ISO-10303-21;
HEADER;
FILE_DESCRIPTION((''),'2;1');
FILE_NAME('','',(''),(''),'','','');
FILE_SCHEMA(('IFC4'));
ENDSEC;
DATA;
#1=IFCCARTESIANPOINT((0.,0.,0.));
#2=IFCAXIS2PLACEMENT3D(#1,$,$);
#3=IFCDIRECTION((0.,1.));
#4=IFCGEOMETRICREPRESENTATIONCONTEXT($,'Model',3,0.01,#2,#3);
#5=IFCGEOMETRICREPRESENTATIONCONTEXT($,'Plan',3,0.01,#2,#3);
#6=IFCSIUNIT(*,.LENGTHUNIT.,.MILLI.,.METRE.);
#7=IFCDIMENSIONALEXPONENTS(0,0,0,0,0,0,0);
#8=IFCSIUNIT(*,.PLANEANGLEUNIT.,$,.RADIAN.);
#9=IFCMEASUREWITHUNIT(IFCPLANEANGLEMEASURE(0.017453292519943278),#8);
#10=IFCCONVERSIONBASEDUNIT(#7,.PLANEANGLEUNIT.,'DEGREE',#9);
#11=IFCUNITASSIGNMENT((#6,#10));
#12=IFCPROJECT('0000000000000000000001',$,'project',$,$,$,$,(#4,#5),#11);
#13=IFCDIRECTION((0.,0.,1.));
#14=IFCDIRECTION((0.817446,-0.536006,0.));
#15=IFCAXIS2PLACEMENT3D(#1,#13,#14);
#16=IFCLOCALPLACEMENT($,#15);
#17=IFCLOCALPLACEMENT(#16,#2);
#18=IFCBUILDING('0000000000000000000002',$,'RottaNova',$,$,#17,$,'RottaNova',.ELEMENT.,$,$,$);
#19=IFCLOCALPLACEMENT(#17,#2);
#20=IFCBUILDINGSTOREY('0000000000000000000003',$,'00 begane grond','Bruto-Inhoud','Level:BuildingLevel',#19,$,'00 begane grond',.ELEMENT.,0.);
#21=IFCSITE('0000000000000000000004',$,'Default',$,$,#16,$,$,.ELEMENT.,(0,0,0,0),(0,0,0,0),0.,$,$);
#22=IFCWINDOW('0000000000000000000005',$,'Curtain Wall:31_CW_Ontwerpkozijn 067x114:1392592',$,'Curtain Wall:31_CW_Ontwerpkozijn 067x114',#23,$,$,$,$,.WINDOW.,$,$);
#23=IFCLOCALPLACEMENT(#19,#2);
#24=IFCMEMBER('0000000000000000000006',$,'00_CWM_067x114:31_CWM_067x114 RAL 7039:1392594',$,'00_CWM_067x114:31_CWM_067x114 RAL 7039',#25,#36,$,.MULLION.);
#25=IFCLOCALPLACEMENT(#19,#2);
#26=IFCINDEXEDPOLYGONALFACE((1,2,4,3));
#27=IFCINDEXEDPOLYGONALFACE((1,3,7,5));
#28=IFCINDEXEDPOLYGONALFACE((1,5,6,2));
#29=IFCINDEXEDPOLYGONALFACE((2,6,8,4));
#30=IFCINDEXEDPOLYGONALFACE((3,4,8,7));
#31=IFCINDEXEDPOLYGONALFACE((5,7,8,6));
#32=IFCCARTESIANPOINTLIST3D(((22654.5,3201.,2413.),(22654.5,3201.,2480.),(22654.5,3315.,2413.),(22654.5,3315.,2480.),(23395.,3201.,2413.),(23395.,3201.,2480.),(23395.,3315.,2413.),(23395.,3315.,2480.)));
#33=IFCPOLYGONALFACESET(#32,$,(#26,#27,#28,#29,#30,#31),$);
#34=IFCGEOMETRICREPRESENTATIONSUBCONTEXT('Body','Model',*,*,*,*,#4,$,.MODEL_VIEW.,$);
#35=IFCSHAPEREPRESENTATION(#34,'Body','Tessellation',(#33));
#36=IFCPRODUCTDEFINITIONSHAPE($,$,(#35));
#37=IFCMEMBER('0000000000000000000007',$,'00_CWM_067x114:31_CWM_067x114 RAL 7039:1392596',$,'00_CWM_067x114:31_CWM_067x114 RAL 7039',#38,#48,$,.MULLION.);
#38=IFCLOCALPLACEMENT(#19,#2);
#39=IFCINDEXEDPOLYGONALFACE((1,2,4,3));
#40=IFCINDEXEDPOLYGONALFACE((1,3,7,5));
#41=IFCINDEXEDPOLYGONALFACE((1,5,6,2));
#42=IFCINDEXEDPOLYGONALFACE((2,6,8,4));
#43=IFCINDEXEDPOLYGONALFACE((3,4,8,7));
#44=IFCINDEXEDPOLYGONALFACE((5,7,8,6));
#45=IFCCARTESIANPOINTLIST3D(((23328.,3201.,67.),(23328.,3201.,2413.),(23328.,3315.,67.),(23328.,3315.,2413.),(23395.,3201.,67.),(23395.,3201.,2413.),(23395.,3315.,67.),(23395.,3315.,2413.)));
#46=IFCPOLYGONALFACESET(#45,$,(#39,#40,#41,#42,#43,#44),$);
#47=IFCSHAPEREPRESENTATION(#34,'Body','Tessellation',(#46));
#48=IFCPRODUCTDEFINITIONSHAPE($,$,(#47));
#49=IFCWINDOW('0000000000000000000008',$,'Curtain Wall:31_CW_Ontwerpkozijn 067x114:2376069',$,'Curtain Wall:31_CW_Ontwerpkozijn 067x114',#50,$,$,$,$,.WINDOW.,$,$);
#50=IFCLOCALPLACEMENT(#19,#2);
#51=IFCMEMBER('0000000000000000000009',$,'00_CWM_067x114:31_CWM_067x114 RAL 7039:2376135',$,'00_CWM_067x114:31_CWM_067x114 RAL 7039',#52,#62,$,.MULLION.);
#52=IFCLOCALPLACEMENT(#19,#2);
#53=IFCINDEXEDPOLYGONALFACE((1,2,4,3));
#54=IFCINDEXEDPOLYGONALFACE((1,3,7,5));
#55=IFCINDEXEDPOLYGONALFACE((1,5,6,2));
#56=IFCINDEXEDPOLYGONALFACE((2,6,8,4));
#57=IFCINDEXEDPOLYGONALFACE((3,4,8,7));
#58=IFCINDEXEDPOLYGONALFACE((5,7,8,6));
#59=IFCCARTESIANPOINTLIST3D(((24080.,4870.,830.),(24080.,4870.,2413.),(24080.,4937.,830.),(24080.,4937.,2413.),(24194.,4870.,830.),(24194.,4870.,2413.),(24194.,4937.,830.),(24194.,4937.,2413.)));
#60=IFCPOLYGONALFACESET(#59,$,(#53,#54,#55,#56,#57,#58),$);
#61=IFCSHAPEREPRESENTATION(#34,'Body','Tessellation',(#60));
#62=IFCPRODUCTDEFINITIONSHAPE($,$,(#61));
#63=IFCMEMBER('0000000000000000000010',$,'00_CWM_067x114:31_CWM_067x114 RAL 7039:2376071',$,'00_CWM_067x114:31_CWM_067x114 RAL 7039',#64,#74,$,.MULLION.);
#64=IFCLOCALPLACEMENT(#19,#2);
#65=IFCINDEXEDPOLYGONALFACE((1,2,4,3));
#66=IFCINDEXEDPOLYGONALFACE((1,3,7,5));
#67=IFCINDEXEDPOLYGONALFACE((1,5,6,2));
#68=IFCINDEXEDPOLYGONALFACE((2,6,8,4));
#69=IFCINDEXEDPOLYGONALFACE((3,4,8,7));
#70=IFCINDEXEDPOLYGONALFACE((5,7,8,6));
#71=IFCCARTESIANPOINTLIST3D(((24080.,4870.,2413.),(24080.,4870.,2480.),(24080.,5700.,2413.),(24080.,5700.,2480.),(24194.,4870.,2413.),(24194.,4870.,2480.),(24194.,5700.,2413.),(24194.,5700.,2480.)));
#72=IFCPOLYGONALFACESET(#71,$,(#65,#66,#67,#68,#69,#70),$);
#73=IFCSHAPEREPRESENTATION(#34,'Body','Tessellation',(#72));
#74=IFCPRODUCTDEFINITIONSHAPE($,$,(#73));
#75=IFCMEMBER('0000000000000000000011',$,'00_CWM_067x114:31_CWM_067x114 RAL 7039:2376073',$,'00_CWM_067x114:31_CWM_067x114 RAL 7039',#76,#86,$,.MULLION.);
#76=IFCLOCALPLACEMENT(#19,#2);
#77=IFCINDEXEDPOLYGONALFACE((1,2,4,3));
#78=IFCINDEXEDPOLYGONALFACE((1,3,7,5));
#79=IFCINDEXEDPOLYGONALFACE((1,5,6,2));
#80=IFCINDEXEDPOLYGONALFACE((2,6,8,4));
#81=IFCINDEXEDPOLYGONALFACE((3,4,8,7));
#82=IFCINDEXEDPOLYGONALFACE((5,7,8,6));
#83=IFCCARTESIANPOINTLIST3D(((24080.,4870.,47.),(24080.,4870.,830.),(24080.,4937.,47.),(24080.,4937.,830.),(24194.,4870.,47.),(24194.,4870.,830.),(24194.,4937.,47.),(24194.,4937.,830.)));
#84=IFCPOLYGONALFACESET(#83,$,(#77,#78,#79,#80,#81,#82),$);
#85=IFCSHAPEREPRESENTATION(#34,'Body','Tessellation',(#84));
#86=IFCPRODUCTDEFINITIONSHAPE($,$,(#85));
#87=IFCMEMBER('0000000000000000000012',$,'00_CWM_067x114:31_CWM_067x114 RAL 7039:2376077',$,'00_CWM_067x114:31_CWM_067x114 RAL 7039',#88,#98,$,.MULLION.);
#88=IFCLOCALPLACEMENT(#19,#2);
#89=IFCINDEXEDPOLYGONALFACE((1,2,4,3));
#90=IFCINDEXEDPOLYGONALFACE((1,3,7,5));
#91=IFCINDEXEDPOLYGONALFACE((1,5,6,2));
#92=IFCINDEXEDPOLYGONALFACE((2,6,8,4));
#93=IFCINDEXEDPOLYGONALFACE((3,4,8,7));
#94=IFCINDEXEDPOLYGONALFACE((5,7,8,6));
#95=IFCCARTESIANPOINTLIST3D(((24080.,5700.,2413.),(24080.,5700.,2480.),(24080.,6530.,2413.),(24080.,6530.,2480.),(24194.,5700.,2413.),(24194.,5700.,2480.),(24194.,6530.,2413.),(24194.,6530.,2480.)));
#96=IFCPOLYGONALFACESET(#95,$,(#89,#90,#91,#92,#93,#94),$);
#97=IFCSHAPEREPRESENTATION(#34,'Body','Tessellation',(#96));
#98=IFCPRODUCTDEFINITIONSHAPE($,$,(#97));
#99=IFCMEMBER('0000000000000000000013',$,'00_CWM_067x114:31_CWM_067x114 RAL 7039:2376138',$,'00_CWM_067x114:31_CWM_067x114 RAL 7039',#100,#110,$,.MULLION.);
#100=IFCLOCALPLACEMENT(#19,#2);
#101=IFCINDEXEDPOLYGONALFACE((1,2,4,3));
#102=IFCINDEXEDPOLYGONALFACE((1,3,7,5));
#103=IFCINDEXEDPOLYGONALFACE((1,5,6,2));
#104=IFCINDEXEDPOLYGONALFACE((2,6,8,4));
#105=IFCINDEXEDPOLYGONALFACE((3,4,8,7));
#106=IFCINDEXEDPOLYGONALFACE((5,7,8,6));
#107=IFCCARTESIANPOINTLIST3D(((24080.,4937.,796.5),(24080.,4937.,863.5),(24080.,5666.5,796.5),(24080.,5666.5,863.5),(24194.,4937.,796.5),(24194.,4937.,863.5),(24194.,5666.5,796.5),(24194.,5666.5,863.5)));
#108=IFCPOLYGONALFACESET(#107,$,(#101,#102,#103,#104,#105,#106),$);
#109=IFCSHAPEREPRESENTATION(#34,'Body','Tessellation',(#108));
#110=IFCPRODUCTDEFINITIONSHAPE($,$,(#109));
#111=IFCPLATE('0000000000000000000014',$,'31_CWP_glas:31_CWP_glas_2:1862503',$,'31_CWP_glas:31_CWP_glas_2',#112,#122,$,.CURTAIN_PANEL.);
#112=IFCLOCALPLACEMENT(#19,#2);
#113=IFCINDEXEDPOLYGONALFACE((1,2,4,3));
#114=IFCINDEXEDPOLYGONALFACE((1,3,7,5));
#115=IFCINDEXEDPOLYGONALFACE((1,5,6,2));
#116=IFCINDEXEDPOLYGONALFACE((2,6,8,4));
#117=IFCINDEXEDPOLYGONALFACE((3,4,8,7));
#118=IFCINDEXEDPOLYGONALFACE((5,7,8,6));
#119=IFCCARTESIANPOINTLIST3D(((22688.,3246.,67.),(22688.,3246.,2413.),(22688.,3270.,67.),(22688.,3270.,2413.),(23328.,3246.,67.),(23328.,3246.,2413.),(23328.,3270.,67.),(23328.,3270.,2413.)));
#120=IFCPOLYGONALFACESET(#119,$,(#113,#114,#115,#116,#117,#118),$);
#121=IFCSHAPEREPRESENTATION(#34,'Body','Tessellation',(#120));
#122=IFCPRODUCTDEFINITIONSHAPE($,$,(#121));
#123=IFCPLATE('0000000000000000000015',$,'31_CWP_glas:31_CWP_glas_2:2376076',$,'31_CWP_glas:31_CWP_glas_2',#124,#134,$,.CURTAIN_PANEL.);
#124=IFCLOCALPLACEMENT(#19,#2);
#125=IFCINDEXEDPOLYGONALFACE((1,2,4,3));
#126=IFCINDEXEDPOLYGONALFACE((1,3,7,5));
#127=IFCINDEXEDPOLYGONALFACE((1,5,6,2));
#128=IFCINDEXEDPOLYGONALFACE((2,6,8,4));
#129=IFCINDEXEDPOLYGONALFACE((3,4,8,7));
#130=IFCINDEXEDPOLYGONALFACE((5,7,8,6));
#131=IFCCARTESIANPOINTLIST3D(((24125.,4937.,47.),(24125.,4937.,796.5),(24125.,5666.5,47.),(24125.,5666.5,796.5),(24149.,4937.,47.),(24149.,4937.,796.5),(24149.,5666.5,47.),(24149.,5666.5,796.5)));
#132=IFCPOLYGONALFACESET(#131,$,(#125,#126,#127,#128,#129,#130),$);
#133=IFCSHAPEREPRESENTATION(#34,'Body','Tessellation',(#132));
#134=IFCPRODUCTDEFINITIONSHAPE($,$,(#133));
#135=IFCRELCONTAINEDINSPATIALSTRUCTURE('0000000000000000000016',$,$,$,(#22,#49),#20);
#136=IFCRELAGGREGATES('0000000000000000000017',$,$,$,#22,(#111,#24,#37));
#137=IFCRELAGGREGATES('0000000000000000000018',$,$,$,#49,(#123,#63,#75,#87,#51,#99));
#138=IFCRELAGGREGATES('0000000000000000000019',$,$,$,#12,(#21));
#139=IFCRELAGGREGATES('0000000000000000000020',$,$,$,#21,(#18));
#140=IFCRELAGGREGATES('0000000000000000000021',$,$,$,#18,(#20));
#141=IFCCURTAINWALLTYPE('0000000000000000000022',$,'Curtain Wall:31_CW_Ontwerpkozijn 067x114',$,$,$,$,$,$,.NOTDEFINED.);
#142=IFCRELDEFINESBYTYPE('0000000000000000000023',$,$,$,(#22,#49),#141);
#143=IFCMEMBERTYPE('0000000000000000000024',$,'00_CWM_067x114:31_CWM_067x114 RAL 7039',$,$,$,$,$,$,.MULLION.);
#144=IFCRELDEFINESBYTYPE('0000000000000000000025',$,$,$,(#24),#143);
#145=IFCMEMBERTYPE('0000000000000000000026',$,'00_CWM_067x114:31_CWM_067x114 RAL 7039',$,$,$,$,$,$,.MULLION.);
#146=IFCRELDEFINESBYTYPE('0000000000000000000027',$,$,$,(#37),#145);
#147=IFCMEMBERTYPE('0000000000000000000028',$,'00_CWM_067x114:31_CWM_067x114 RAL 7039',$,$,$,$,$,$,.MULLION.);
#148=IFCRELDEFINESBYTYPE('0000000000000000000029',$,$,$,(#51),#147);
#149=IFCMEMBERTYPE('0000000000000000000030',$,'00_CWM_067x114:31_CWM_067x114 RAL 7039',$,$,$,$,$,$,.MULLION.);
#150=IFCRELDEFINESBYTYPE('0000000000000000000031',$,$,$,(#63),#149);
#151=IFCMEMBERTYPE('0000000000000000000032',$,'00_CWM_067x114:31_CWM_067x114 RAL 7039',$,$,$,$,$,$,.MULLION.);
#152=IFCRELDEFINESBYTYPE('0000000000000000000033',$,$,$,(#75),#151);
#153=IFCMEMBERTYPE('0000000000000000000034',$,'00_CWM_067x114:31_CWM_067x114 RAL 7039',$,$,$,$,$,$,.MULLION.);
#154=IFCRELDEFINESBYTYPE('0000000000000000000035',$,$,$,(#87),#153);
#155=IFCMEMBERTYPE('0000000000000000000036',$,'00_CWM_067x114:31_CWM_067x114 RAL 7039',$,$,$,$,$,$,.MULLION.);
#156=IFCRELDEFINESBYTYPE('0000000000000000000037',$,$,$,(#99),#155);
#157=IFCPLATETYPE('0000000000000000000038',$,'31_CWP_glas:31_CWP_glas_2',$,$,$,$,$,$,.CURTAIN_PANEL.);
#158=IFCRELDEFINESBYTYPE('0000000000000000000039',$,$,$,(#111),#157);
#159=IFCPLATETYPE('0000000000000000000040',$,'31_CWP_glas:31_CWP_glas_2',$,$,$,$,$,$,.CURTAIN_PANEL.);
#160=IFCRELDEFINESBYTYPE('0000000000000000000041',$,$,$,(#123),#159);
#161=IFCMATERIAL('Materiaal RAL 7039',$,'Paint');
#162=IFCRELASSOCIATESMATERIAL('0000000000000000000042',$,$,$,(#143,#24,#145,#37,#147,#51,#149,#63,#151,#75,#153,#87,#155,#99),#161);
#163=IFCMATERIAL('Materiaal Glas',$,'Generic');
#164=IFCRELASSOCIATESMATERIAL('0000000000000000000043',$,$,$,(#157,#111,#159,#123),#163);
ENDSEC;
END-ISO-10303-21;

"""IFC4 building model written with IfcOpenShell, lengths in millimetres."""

from ifc_helpers import new_model, entity, si_unit, converted_unit, direction, frame, origin, place, context, subcontext, project, spatial, indexed_curve, outline, extrude, source, transform, mapped, material, type_object, type_shapes, element, aggregate, save


model = new_model("IFC4")

# Units and contexts
model_context = context("Model", 3, precision=0.01, world=origin(), true_north=direction((0.0, 1.0)))
plan_context = context("Plan", 3, precision=0.01, world=origin(), true_north=direction((0.0, 1.0)))
body_context = subcontext(model_context, "Body", "Model", "MODEL_VIEW")
ifc_project = project(units=[si_unit("LENGTHUNIT", "METRE", prefix="MILLI"), converted_unit("PLANEANGLEUNIT", "DEGREE", entity("IfcPlaneAngleMeasure", 0.017453292519943278), si_unit("PLANEANGLEUNIT", "RADIAN"), dimensions=[0, 0, 0, 0, 0, 0, 0])], contexts=[model_context, plan_context])

# Site, building, storey
site_placement = place(None, frame((0.0, 0.0, 0.0), z_axis=(0.0, 0.0, 1.0), x_axis=(0.817446, -0.536006, 0.0)))
site = spatial("IfcSite", under=ifc_project, at=site_placement, Name="Default", CompositionType="ELEMENT", RefLatitude=(0, 0, 0, 0), RefLongitude=(0, 0, 0, 0), RefElevation=0.0)
building_placement = place(site_placement, origin())
building = spatial("IfcBuilding", under=site, at=building_placement, Name="RottaNova", LongName="RottaNova", CompositionType="ELEMENT")
storey_placement = place(building_placement, origin())
storey = spatial("IfcBuildingStorey", under=building, at=storey_placement, Name="00 begane grond", Description="Bruto-Inhoud", ObjectType="Level:BuildingLevel", LongName="00 begane grond", CompositionType="ELEMENT", Elevation=0.0)

# Windows, members
curtain_wall_type = type_object("IfcCurtainWallType", Name="Curtain Wall:31_CW_Ontwerpkozijn 067x114", PredefinedType="NOTDEFINED")
window_1_placement = place(storey_placement, origin())
window_1 = element("IfcWindow", 1, at=window_1_placement, inside=storey, type_object=curtain_wall_type, Name="Curtain Wall:31_CW_Ontwerpkozijn 067x114:1392592", ObjectType="Curtain Wall:31_CW_Ontwerpkozijn 067x114", PredefinedType="WINDOW")
ifc_material_1 = material(Name="Materiaal RAL 7039", Category="Paint")
member_type_1 = type_object("IfcMemberType", Name="00_CWM_067x114:31_CWM_067x114 RAL 7039", PredefinedType="MULLION", material=ifc_material_1)
shared_shape_1 = source(origin(), body_context, "Body", "SweptSolid", [
    extrude(outline(indexed_curve([(-33.5, -57.0), (33.5, -57.0), (33.5, 57.0), (-33.5, 57.0), (-33.5, -57.0)], self_intersect=False)), frame((-33.5, 57.0, -740.5), z_axis=(0.0, 0.0, 1.0), x_axis=(-1.0, 0.0, 0.0)), (0.0, 0.0, 1.0), 740.5),
])
type_shapes(member_type_1, [shared_shape_1])
member_1_placement = place(window_1_placement, frame((23395.0, 3315.0, 2480.0), z_axis=(1.0, 0.0, 0.0), x_axis=(0.0, 0.0, 1.0)))
member_1 = element("IfcMember", 2, at=member_1_placement, type_object=member_type_1, material=ifc_material_1, Name="00_CWM_067x114:31_CWM_067x114 RAL 7039:1392594", ObjectType="00_CWM_067x114:31_CWM_067x114 RAL 7039", PredefinedType="MULLION", context=body_context, shape_type="MappedRepresentation", body=[
    mapped(shared_shape_1, transform((0.0, 0.0, 0.0), scale=1.0)),
])
member_type_2 = type_object("IfcMemberType", Name="00_CWM_067x114:31_CWM_067x114 RAL 7039", PredefinedType="MULLION", material=ifc_material_1)
shared_shape_2 = source(origin(), body_context, "Body", "SweptSolid", [
    extrude(outline(indexed_curve([(-33.5, -57.0), (33.5, -57.0), (33.5, 57.0), (-33.5, 57.0), (-33.5, -57.0)], self_intersect=False)), frame((-33.5, 57.0, -2346.0), z_axis=(0.0, 0.0, 1.0), x_axis=(-1.0, 0.0, 0.0)), (0.0, 0.0, 1.0), 2346.0),
])
type_shapes(member_type_2, [shared_shape_2])
member_2_placement = place(window_1_placement, frame((23395.0, 3315.0, 67.0), z_axis=(0.0, 0.0, -1.0), x_axis=(1.0, 0.0, 0.0)))
member_2 = element("IfcMember", 3, at=member_2_placement, type_object=member_type_2, material=ifc_material_1, Name="00_CWM_067x114:31_CWM_067x114 RAL 7039:1392596", ObjectType="00_CWM_067x114:31_CWM_067x114 RAL 7039", PredefinedType="MULLION", context=body_context, shape_type="MappedRepresentation", body=[
    mapped(shared_shape_2, transform((0.0, 0.0, 0.0), scale=1.0)),
])
window_2_placement = place(storey_placement, origin())
window_2 = element("IfcWindow", 4, at=window_2_placement, inside=storey, type_object=curtain_wall_type, Name="Curtain Wall:31_CW_Ontwerpkozijn 067x114:2376069", ObjectType="Curtain Wall:31_CW_Ontwerpkozijn 067x114", PredefinedType="WINDOW")
member_type_3 = type_object("IfcMemberType", Name="00_CWM_067x114:31_CWM_067x114 RAL 7039", PredefinedType="MULLION", material=ifc_material_1)
shared_shape_3 = source(origin(), body_context, "Body", "SweptSolid", [
    extrude(outline(indexed_curve([(-33.5, -57.0), (33.5, -57.0), (33.5, 57.0), (-33.5, 57.0), (-33.5, -57.0)], self_intersect=False)), frame((-33.5, -57.0, -1583.0), z_axis=(0.0, 0.0, 1.0), x_axis=(-1.0, 0.0, 0.0)), (0.0, 0.0, 1.0), 1583.0),
])
type_shapes(member_type_3, [shared_shape_3])
member_3_placement = place(window_2_placement, frame((24080.0, 4870.0, 830.0), z_axis=(0.0, 0.0, -1.0), x_axis=(0.0, -1.0, 0.0)))
member_3 = element("IfcMember", 5, at=member_3_placement, type_object=member_type_3, material=ifc_material_1, Name="00_CWM_067x114:31_CWM_067x114 RAL 7039:2376135", ObjectType="00_CWM_067x114:31_CWM_067x114 RAL 7039", PredefinedType="MULLION", context=body_context, shape_type="MappedRepresentation", body=[
    mapped(shared_shape_3, transform((0.0, 0.0, 0.0), scale=1.0)),
])
member_type_4 = type_object("IfcMemberType", Name="00_CWM_067x114:31_CWM_067x114 RAL 7039", PredefinedType="MULLION", material=ifc_material_1)
shared_shape_4 = source(origin(), body_context, "Body", "SweptSolid", [
    extrude(outline(indexed_curve([(-33.5, -57.0), (33.5, -57.0), (33.5, 57.0), (-33.5, 57.0), (-33.5, -57.0)], self_intersect=False)), frame((-33.5, -57.0, -830.0), z_axis=(0.0, 0.0, 1.0), x_axis=(-1.0, 0.0, 0.0)), (0.0, 0.0, 1.0), 830.0),
])
type_shapes(member_type_4, [shared_shape_4])
member_4_placement = place(window_2_placement, frame((24080.0, 4870.0, 2480.0), z_axis=(0.0, -1.0, 0.0), x_axis=(0.0, 0.0, 1.0)))
member_4 = element("IfcMember", 6, at=member_4_placement, type_object=member_type_4, material=ifc_material_1, Name="00_CWM_067x114:31_CWM_067x114 RAL 7039:2376071", ObjectType="00_CWM_067x114:31_CWM_067x114 RAL 7039", PredefinedType="MULLION", context=body_context, shape_type="MappedRepresentation", body=[
    mapped(shared_shape_4, transform((0.0, 0.0, 0.0), scale=1.0)),
])
member_type_5 = type_object("IfcMemberType", Name="00_CWM_067x114:31_CWM_067x114 RAL 7039", PredefinedType="MULLION", material=ifc_material_1)
shared_shape_5 = source(origin(), body_context, "Body", "SweptSolid", [
    extrude(outline(indexed_curve([(-33.5, -57.0), (33.5, -57.0), (33.5, 57.0), (-33.5, 57.0), (-33.5, -57.0)], self_intersect=False)), frame((-33.5, -57.0, -783.0), z_axis=(0.0, 0.0, 1.0), x_axis=(-1.0, 0.0, 0.0)), (0.0, 0.0, 1.0), 783.0),
])
type_shapes(member_type_5, [shared_shape_5])
member_5_placement = place(window_2_placement, frame((24080.0, 4870.0, 47.0), z_axis=(0.0, 0.0, -1.0), x_axis=(0.0, -1.0, 0.0)))
member_5 = element("IfcMember", 7, at=member_5_placement, type_object=member_type_5, material=ifc_material_1, Name="00_CWM_067x114:31_CWM_067x114 RAL 7039:2376073", ObjectType="00_CWM_067x114:31_CWM_067x114 RAL 7039", PredefinedType="MULLION", context=body_context, shape_type="MappedRepresentation", body=[
    mapped(shared_shape_5, transform((0.0, 0.0, 0.0), scale=1.0)),
])
member_type_6 = type_object("IfcMemberType", Name="00_CWM_067x114:31_CWM_067x114 RAL 7039", PredefinedType="MULLION", material=ifc_material_1)
shared_shape_6 = source(origin(), body_context, "Body", "SweptSolid", [
    extrude(outline(indexed_curve([(-33.5, -57.0), (33.5, -57.0), (33.5, 57.0), (-33.5, 57.0), (-33.5, -57.0)], self_intersect=False)), frame((-33.5, -57.0, -830.0), z_axis=(0.0, 0.0, 1.0), x_axis=(-1.0, 0.0, 0.0)), (0.0, 0.0, 1.0), 830.0),
])
type_shapes(member_type_6, [shared_shape_6])
member_6_placement = place(window_2_placement, frame((24080.0, 5700.0, 2480.0), z_axis=(0.0, -1.0, 0.0), x_axis=(0.0, 0.0, 1.0)))
member_6 = element("IfcMember", 8, at=member_6_placement, type_object=member_type_6, material=ifc_material_1, Name="00_CWM_067x114:31_CWM_067x114 RAL 7039:2376077", ObjectType="00_CWM_067x114:31_CWM_067x114 RAL 7039", PredefinedType="MULLION", context=body_context, shape_type="MappedRepresentation", body=[
    mapped(shared_shape_6, transform((0.0, 0.0, 0.0), scale=1.0)),
])
member_type_7 = type_object("IfcMemberType", Name="00_CWM_067x114:31_CWM_067x114 RAL 7039", PredefinedType="MULLION", material=ifc_material_1)
shared_shape_7 = source(origin(), body_context, "Body", "SweptSolid", [
    extrude(outline(indexed_curve([(-33.5, -57.0), (33.5, -57.0), (33.5, 57.0), (-33.5, 57.0), (-33.5, -57.0)], self_intersect=False)), frame((0.0, -57.0, -729.5), z_axis=(0.0, 0.0, 1.0), x_axis=(-1.0, 0.0, 0.0)), (0.0, 0.0, 1.0), 729.5),
])
type_shapes(member_type_7, [shared_shape_7])
member_7_placement = place(window_2_placement, frame((24080.0, 4937.0, 830.0), z_axis=(0.0, -1.0, 0.0), x_axis=(0.0, 0.0, 1.0)))
member_7 = element("IfcMember", 9, at=member_7_placement, type_object=member_type_7, material=ifc_material_1, Name="00_CWM_067x114:31_CWM_067x114 RAL 7039:2376138", ObjectType="00_CWM_067x114:31_CWM_067x114 RAL 7039", PredefinedType="MULLION", context=body_context, shape_type="MappedRepresentation", body=[
    mapped(shared_shape_7, transform((0.0, 0.0, 0.0), scale=1.0)),
])

# Plates
ifc_material_2 = material(Name="Materiaal Glas", Category="Generic")
plate_type_1 = type_object("IfcPlateType", Name="31_CWP_glas:31_CWP_glas_2", PredefinedType="CURTAIN_PANEL", material=ifc_material_2)
shared_shape_8 = source(origin(), body_context, "Body", "SweptSolid", [
    extrude(outline(indexed_curve([(-12.0, -320.0), (12.0, -320.0), (12.0, 320.0), (-12.0, 320.0), (-12.0, -320.0)], self_intersect=False)), frame((0.0, -57.0, 0.0), z_axis=(0.0, 0.0, 1.0), x_axis=(0.0, 1.0, 0.0)), (0.0, 0.0, 1.0), 2346.0),
])
type_shapes(plate_type_1, [shared_shape_8])
plate_1_placement = place(window_1_placement, frame((23008.0, 3315.0, 67.0)))
plate_1 = element("IfcPlate", 10, at=plate_1_placement, type_object=plate_type_1, material=ifc_material_2, Name="31_CWP_glas:31_CWP_glas_2:1862503", ObjectType="31_CWP_glas:31_CWP_glas_2", PredefinedType="CURTAIN_PANEL", context=body_context, shape_type="MappedRepresentation", body=[
    mapped(shared_shape_8, transform((0.0, 0.0, 0.0), scale=1.0)),
])
aggregate(window_1, [plate_1, member_1, member_2])
plate_type_2 = type_object("IfcPlateType", Name="31_CWP_glas:31_CWP_glas_2", PredefinedType="CURTAIN_PANEL", material=ifc_material_2)
shared_shape_9 = source(origin(), body_context, "Body", "SweptSolid", [
    extrude(outline(indexed_curve([(-12.0, -364.7), (12.0, -364.7), (12.0, 364.7), (-12.0, 364.7), (-12.0, -364.7)], self_intersect=False)), frame((0.0, 57.0, 0.0), z_axis=(0.0, 0.0, 1.0), x_axis=(0.0, 1.0, 0.0)), (0.0, 0.0, 1.0), 749.5),
])
type_shapes(plate_type_2, [shared_shape_9])
plate_2_placement = place(window_2_placement, frame((24080.0, 5301.7, 47.0), z_axis=(0.0, 0.0, 1.0), x_axis=(0.0, -1.0, 0.0)))
plate_2 = element("IfcPlate", 11, at=plate_2_placement, type_object=plate_type_2, material=ifc_material_2, Name="31_CWP_glas:31_CWP_glas_2:2376076", ObjectType="31_CWP_glas:31_CWP_glas_2", PredefinedType="CURTAIN_PANEL", context=body_context, shape_type="MappedRepresentation", body=[
    mapped(shared_shape_9, transform((0.0, 0.0, 0.0), scale=1.0)),
])
aggregate(window_2, [plate_2, member_4, member_5, member_6, member_3, member_7])

save(model, "model.ifc")
